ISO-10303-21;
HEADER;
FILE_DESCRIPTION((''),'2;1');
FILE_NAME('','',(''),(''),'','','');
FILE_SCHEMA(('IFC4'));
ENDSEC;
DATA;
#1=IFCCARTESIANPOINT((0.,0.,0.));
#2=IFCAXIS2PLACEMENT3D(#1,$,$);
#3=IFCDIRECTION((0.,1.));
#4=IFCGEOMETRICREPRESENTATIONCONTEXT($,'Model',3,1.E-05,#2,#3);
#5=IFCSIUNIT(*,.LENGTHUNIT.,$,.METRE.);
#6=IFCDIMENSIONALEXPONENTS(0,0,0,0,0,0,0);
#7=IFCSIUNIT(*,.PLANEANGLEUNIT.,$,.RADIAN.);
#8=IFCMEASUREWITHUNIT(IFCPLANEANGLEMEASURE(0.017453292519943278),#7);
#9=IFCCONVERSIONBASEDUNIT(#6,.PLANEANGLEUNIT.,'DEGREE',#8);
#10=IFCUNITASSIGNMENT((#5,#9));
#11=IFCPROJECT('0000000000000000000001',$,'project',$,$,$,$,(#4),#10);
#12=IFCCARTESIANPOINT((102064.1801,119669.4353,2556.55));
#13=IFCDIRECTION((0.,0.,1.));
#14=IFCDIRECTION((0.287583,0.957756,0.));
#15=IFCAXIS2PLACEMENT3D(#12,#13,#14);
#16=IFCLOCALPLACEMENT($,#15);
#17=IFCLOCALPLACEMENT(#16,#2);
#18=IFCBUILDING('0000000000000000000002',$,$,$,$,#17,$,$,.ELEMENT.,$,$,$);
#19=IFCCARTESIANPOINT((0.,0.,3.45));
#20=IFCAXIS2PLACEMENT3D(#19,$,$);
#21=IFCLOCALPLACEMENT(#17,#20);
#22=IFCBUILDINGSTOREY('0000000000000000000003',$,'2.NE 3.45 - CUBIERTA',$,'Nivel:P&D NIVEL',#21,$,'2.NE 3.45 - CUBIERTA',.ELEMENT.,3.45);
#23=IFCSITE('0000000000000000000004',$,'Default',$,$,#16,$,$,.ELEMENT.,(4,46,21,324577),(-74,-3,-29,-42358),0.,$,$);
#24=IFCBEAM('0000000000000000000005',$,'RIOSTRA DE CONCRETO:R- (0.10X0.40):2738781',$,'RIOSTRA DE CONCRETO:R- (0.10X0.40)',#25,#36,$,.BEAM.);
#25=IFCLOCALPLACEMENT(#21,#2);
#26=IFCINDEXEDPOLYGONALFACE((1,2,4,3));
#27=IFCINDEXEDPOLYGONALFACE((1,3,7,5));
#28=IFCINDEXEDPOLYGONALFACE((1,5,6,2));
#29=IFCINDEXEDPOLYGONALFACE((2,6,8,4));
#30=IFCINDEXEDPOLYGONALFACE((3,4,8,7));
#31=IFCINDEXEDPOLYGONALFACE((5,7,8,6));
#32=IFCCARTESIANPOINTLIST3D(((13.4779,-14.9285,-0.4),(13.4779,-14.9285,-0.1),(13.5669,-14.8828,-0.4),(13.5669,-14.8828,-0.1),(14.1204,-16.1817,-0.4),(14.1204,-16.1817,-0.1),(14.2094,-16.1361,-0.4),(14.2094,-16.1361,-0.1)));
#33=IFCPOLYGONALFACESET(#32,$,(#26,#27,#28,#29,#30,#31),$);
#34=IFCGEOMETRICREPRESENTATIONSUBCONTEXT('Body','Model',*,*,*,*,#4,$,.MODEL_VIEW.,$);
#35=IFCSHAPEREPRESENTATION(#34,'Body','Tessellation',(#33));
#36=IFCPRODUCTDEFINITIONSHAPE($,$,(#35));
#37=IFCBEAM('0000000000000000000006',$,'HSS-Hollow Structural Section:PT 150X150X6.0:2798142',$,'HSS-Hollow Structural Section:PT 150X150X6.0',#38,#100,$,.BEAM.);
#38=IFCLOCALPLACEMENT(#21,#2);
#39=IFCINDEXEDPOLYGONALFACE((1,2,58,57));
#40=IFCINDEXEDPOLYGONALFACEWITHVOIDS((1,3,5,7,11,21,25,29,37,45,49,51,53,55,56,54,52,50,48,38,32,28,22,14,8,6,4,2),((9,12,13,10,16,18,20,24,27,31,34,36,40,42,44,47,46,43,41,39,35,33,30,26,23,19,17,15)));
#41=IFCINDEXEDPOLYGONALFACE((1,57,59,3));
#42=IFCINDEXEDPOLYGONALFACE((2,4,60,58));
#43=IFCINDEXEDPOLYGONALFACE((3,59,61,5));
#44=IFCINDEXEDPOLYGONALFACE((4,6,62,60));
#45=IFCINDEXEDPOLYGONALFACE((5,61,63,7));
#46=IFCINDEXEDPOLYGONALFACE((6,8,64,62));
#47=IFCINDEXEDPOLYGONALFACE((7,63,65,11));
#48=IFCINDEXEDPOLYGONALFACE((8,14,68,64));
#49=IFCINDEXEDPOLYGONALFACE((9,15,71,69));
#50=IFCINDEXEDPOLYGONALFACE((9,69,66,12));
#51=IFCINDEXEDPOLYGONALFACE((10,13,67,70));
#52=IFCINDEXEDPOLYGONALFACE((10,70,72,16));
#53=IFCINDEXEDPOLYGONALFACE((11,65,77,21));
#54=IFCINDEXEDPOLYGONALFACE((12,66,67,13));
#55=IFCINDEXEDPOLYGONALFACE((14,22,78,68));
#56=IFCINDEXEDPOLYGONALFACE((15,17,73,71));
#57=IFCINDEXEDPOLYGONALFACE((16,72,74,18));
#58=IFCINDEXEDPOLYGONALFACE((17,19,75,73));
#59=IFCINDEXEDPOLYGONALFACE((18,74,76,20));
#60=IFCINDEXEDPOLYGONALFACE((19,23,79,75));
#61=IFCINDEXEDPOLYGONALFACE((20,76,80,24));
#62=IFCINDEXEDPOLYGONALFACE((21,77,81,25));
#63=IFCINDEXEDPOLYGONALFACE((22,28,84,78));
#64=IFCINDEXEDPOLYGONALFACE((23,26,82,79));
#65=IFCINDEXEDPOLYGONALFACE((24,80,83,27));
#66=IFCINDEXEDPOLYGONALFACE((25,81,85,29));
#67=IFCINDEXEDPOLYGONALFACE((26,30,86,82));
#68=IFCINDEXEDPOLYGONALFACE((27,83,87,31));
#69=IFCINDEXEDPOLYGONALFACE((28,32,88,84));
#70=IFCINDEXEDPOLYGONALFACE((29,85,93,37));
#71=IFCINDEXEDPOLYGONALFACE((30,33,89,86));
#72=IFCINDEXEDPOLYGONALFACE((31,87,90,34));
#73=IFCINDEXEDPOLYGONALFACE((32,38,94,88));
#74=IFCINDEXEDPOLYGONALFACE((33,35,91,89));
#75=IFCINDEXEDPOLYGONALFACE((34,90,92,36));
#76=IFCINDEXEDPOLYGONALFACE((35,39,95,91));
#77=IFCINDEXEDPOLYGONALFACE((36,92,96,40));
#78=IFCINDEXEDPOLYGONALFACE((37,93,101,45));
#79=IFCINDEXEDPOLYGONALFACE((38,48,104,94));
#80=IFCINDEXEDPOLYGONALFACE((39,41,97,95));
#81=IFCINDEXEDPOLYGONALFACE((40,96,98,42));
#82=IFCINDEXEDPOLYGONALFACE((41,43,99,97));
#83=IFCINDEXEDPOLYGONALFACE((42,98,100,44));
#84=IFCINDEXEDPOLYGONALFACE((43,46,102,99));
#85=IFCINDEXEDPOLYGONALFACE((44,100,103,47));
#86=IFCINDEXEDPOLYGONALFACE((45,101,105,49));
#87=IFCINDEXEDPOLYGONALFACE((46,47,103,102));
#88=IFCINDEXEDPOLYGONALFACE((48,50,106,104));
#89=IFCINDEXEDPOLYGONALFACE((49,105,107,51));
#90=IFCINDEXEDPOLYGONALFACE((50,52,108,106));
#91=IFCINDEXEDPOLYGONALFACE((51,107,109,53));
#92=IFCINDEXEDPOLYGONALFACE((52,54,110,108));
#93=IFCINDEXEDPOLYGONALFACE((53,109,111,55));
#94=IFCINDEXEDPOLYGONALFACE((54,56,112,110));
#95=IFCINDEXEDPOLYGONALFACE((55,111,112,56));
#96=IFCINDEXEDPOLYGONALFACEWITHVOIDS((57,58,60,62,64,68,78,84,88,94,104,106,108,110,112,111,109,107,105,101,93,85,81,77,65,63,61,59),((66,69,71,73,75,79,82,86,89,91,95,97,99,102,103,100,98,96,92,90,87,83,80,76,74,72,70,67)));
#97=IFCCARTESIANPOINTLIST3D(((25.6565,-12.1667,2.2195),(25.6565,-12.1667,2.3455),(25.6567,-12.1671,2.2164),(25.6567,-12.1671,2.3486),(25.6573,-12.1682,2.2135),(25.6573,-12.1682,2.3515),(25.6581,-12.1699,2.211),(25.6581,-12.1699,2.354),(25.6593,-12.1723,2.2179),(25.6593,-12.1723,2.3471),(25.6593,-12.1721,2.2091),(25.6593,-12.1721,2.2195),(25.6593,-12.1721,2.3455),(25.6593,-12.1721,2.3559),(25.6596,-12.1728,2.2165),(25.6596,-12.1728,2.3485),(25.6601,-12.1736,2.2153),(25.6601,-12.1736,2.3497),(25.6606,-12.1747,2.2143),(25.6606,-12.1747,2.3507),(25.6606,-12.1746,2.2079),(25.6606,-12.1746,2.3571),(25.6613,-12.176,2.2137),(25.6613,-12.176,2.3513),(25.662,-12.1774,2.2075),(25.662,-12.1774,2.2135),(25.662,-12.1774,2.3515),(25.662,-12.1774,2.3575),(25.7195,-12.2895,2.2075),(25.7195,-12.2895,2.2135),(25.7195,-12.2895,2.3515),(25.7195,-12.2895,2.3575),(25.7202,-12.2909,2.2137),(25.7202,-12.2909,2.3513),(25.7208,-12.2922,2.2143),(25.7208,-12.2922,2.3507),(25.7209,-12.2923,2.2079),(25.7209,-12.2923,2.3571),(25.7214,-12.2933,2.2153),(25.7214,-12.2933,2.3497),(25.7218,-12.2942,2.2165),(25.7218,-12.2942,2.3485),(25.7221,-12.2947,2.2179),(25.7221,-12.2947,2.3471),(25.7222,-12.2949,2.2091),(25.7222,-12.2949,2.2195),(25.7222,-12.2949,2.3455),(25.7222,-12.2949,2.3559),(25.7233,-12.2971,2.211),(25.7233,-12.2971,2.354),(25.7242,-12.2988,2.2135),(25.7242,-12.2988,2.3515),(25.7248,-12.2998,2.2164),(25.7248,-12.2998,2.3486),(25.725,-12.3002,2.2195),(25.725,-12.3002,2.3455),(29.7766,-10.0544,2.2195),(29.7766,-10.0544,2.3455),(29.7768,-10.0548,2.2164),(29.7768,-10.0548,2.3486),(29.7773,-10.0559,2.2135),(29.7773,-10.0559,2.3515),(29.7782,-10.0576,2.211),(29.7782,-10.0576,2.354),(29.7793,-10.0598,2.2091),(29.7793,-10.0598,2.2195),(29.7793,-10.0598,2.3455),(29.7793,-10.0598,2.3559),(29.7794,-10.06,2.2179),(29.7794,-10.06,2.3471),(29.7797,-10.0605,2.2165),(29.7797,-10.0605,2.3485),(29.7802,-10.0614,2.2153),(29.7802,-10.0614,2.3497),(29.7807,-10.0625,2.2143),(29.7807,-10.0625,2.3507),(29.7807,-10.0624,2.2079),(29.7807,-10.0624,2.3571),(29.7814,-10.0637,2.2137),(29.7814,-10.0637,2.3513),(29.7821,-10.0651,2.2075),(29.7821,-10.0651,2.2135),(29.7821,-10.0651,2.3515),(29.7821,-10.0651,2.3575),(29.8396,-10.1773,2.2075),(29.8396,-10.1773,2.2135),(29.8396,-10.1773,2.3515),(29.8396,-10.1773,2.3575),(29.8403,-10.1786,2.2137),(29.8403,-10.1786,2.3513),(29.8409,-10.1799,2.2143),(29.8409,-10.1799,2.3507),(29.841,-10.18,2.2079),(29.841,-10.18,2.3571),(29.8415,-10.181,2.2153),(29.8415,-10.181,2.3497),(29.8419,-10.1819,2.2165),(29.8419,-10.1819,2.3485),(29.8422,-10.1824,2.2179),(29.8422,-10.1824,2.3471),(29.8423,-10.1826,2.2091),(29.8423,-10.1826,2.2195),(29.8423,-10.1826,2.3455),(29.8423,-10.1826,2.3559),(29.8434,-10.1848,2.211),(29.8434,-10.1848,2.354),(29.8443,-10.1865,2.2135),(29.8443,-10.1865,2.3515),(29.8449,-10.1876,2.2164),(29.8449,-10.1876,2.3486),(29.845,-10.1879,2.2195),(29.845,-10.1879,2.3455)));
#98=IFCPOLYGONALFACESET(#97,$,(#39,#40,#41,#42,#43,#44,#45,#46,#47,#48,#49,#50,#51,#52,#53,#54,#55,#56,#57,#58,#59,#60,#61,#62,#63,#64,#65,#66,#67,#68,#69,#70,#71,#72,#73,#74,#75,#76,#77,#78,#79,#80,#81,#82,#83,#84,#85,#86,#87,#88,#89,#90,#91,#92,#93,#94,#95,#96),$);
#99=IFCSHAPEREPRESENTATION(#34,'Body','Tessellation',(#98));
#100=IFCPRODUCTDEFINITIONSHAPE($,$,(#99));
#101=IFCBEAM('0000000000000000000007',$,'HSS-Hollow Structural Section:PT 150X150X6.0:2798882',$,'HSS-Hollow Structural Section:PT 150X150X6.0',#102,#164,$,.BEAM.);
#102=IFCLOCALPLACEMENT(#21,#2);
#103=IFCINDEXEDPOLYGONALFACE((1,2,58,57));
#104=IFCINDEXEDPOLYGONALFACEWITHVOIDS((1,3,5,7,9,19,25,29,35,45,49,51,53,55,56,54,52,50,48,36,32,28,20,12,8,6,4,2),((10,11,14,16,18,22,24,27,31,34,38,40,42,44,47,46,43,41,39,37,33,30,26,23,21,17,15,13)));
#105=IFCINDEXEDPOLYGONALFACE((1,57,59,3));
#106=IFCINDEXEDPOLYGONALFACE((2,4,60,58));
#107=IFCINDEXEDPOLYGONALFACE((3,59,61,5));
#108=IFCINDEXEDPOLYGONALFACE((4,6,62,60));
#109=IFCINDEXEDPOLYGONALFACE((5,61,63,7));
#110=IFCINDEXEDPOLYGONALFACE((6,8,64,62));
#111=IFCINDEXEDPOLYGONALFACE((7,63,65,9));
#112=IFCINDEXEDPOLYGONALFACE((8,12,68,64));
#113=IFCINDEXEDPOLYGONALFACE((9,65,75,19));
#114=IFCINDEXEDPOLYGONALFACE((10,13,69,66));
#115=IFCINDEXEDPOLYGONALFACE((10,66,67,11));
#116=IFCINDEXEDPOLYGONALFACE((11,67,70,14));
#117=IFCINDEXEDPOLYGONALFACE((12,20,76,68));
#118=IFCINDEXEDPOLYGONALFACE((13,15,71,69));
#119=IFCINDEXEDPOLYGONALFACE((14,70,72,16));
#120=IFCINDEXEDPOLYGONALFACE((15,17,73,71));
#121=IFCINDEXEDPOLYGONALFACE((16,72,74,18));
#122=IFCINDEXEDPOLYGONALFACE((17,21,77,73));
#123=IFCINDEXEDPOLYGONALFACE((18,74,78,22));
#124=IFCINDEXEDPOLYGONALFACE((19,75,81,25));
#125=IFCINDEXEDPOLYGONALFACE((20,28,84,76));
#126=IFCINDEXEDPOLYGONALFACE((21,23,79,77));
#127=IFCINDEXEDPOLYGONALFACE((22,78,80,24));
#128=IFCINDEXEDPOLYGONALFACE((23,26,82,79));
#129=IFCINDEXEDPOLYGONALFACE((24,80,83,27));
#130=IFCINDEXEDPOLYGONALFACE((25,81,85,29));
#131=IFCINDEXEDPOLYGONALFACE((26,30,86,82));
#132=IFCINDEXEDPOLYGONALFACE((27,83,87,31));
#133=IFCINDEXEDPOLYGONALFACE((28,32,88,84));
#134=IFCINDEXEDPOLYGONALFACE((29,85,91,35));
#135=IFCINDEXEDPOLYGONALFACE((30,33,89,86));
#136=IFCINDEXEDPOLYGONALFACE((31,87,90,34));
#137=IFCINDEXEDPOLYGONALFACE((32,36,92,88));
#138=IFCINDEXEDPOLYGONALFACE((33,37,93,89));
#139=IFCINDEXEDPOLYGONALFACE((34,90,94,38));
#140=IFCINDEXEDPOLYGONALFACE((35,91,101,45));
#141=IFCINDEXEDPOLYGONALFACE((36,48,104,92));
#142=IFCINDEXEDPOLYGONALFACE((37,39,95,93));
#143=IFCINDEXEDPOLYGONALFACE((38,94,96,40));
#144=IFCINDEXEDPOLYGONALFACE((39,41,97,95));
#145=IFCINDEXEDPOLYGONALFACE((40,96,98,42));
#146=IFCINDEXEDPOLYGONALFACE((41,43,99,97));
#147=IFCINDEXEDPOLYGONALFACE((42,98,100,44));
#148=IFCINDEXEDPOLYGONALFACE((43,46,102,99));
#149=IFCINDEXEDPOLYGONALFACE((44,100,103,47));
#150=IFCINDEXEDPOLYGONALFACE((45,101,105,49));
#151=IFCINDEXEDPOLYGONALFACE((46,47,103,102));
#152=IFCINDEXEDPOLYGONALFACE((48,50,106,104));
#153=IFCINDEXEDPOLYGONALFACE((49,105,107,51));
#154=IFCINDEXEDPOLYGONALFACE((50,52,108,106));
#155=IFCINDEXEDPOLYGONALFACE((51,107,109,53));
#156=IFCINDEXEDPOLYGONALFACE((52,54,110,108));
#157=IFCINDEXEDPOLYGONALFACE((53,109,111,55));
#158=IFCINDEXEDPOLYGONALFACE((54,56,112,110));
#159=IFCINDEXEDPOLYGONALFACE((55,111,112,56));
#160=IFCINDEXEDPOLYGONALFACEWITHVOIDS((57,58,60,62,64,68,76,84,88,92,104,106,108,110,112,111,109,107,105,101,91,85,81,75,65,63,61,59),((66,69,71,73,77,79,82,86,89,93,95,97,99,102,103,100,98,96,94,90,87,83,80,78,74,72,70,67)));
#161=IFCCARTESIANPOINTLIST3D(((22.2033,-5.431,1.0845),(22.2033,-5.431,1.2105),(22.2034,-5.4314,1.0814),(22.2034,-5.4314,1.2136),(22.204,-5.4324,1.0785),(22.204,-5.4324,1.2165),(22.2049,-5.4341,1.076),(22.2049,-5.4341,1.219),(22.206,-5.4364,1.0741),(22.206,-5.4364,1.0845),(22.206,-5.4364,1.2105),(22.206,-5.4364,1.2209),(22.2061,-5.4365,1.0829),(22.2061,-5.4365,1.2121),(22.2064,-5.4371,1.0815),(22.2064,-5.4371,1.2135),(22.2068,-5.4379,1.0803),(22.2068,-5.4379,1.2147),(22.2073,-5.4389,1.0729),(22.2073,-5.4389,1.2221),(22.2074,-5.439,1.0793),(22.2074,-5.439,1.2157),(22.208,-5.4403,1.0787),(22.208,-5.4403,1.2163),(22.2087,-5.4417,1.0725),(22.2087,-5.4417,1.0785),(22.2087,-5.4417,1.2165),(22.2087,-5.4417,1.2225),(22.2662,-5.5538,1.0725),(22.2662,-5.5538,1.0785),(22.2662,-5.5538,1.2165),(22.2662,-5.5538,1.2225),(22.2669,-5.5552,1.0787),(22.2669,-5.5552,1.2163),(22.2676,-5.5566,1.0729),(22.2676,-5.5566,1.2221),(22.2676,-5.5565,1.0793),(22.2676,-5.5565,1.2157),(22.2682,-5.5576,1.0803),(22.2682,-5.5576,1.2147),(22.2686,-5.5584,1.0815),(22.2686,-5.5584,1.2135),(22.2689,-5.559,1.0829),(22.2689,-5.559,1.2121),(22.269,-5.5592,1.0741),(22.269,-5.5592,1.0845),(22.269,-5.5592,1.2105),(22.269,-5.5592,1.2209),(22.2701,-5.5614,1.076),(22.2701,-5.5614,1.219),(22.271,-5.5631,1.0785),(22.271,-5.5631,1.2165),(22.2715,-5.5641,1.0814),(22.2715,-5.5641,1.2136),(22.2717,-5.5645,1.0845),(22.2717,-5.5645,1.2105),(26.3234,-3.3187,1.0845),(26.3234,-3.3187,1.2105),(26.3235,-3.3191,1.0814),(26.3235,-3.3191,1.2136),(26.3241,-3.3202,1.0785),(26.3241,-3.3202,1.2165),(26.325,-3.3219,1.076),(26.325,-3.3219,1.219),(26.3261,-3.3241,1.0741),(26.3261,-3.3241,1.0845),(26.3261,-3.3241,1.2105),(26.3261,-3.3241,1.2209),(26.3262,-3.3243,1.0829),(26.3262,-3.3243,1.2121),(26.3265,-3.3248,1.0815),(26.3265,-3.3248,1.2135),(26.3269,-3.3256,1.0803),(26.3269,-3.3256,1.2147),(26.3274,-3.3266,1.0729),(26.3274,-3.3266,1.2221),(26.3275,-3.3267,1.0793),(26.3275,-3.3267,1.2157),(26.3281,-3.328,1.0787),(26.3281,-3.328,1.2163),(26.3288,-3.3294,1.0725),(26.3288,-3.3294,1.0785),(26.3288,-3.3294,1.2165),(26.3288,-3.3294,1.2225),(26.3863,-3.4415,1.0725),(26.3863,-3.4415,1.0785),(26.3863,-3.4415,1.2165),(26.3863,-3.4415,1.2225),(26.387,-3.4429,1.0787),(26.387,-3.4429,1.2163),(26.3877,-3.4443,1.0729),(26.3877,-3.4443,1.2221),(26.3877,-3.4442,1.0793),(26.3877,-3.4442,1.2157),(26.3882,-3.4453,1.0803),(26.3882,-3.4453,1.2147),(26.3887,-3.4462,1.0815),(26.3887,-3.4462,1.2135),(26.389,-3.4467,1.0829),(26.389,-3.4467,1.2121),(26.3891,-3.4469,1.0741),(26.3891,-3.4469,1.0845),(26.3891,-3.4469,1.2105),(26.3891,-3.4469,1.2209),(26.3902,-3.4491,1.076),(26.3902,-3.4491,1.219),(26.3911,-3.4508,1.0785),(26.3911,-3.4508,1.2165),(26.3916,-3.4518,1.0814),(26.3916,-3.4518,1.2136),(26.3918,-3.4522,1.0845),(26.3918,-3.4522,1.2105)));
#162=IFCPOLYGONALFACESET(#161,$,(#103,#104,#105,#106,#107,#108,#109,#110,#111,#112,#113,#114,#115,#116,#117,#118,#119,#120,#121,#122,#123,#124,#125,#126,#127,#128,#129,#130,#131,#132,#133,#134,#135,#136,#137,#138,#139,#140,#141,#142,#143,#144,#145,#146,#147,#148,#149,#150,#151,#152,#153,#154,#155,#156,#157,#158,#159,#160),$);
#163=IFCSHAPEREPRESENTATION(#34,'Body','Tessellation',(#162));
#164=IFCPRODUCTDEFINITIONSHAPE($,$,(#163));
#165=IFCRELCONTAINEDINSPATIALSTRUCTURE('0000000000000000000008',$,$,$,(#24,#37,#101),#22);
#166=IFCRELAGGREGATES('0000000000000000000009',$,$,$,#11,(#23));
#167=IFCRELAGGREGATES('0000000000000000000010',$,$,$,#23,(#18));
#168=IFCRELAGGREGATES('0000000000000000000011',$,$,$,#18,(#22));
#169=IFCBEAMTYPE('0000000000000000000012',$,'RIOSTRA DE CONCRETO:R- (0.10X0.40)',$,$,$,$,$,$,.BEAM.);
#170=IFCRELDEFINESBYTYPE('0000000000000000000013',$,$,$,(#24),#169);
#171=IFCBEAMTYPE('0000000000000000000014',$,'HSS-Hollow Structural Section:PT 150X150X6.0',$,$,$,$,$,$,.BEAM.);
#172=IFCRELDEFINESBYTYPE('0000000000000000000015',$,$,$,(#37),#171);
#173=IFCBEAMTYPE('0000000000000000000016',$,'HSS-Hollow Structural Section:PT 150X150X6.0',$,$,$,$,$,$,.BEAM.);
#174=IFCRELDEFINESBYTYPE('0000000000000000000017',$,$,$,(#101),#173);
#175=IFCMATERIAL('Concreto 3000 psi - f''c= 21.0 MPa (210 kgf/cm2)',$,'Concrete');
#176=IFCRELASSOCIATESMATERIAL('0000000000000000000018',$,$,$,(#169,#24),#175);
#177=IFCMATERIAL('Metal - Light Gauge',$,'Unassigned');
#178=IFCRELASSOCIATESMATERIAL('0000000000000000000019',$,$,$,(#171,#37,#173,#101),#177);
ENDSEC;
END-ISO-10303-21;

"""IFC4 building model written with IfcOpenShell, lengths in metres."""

from ifc_helpers import new_model, entity, si_unit, converted_unit, direction, frame, origin, place, context, subcontext, project, spatial, line, arc, indexed_curve, outline, extrude, source, transform, mapped, material, type_object, type_shapes, element, save


model = new_model("IFC4")

# Units and contexts
model_context = context("Model", 3, precision=1e-05, world=origin(), true_north=direction((0.0, 1.0)))
body_context = subcontext(model_context, "Body", "Model", "MODEL_VIEW")
ifc_project = project(units=[si_unit("LENGTHUNIT", "METRE"), converted_unit("PLANEANGLEUNIT", "DEGREE", entity("IfcPlaneAngleMeasure", 0.017453292519943278), si_unit("PLANEANGLEUNIT", "RADIAN"), dimensions=[0, 0, 0, 0, 0, 0, 0])], contexts=[model_context])

# Site, building, storey
site_placement = place(None, frame((102064.1801, 119669.4353, 2556.55), z_axis=(0.0, 0.0, 1.0), x_axis=(0.287583, 0.957756, 0.0)))
site = spatial("IfcSite", under=ifc_project, at=site_placement, Name="Default", CompositionType="ELEMENT", RefLatitude=(4, 46, 21, 324577), RefLongitude=(-74, -3, -29, -42358), RefElevation=0.0)
building_placement = place(site_placement, origin())
building = spatial("IfcBuilding", under=site, at=building_placement, CompositionType="ELEMENT")
storey_placement = place(building_placement, frame((0.0, 0.0, 3.45)))
storey = spatial("IfcBuildingStorey", under=building, at=storey_placement, Name="2.NE 3.45 - CUBIERTA", ObjectType="Nivel:P&D NIVEL", LongName="2.NE 3.45 - CUBIERTA", CompositionType="ELEMENT", Elevation=3.45)

# Beams
ifc_material_1 = material(Name="Metal - Light Gauge", Category="Unassigned")
ifc_material_2 = material(Name="Concreto 3000 psi - f'c= 21.0 MPa (210 kgf/cm2)", Category="Concrete")
beam_type_1 = type_object("IfcBeamType", Name="RIOSTRA DE CONCRETO:R- (0.10X0.40)", PredefinedType="BEAM", material=ifc_material_2)
shared_shape_1 = source(origin(), body_context, "Body", "SweptSolid", [
    extrude(outline(indexed_curve([(-0.15, -0.05), (0.15, -0.05), (0.15, 0.05), (-0.15, 0.05), (-0.15, -0.05)], self_intersect=False)), frame((13.5224, -14.9056, 3.2), z_axis=(0.456217, -0.889869, 0.0), x_axis=(0.0, 0.0, -1.0)), (0.0, 0.0, 1.0), 1.4083),
])
type_shapes(beam_type_1, [shared_shape_1])
beam_1_placement = place(storey_placement, frame((0.0, 0.0, -3.45)))
element("IfcBeam", 1, at=beam_1_placement, inside=storey, type_object=beam_type_1, material=ifc_material_2, Name="RIOSTRA DE CONCRETO:R- (0.10X0.40):2738781", ObjectType="RIOSTRA DE CONCRETO:R- (0.10X0.40)", PredefinedType="BEAM", context=body_context, shape_type="MappedRepresentation", body=[
    mapped(shared_shape_1, transform((0.0, 0.0, 0.0), scale=1.0)),
])
beam_type_2 = type_object("IfcBeamType", Name="HSS-Hollow Structural Section:PT 150X150X6.0", PredefinedType="BEAM", material=ifc_material_1)
shared_shape_2 = source(origin(), body_context, "Body", "SweptSolid", [
    extrude(outline(indexed_curve([(-0.063, -0.075), (0.063, -0.075), (0.0715, -0.0715), (0.075, -0.063), (0.075, 0.063), (0.0715, 0.0715), (0.063, 0.075), (-0.063, 0.075), (-0.0715, 0.0715), (-0.075, 0.063), (-0.075, -0.063), (-0.0715, -0.0715)], segments=[line(1, 2), arc(2, 3, 4), line(4, 5), arc(5, 6, 7), line(7, 8), arc(8, 9, 10), line(10, 11), arc(11, 12, 1)], self_intersect=False), holes=[indexed_curve([(-0.069, 0.063), (-0.0672, 0.0672), (-0.063, 0.069), (0.063, 0.069), (0.0672, 0.0672), (0.069, 0.063), (0.069, -0.063), (0.0672, -0.0672), (0.063, -0.069), (-0.063, -0.069), (-0.0672, -0.0672), (-0.069, -0.063)], segments=[arc(1, 2, 3), line(3, 4), arc(4, 5, 6), line(6, 7), arc(7, 8, 9), line(9, 10), arc(10, 11, 12), line(12, 1)], self_intersect=False)]), frame((25.6907, -12.2335, 5.7325), z_axis=(0.889869, 0.456217, 0.0), x_axis=(0.0, 0.0, -1.0)), (0.0, 0.0, 1.0), 4.63),
])
type_shapes(beam_type_2, [shared_shape_2])
beam_2_placement = place(storey_placement, frame((0.0, 0.0, -3.45)))
element("IfcBeam", 2, at=beam_2_placement, inside=storey, type_object=beam_type_2, material=ifc_material_1, Name="HSS-Hollow Structural Section:PT 150X150X6.0:2798142", ObjectType="HSS-Hollow Structural Section:PT 150X150X6.0", PredefinedType="BEAM", context=body_context, shape_type="MappedRepresentation", body=[
    mapped(shared_shape_2, transform((0.0, 0.0, 0.0), scale=1.0)),
])
beam_type_3 = type_object("IfcBeamType", Name="HSS-Hollow Structural Section:PT 150X150X6.0", PredefinedType="BEAM", material=ifc_material_1)
shared_shape_3 = source(origin(), body_context, "Body", "SweptSolid", [
    extrude(outline(indexed_curve([(-0.063, -0.075), (0.063, -0.075), (0.0715, -0.0715), (0.075, -0.063), (0.075, 0.063), (0.0715, 0.0715), (0.063, 0.075), (-0.063, 0.075), (-0.0715, 0.0715), (-0.075, 0.063), (-0.075, -0.063), (-0.0715, -0.0715)], segments=[line(1, 2), arc(2, 3, 4), line(4, 5), arc(5, 6, 7), line(7, 8), arc(8, 9, 10), line(10, 11), arc(11, 12, 1)], self_intersect=False), holes=[indexed_curve([(-0.069, 0.063), (-0.0672, 0.0672), (-0.063, 0.069), (0.063, 0.069), (0.0672, 0.0672), (0.069, 0.063), (0.069, -0.063), (0.0672, -0.0672), (0.063, -0.069), (-0.063, -0.069), (-0.0672, -0.0672), (-0.069, -0.063)], segments=[arc(1, 2, 3), line(3, 4), arc(4, 5, 6), line(6, 7), arc(7, 8, 9), line(9, 10), arc(10, 11, 12), line(12, 1)], self_intersect=False)]), frame((22.2375, -5.4978, 4.5975), z_axis=(0.889869, 0.456217, 0.0), x_axis=(0.0, 0.0, -1.0)), (0.0, 0.0, 1.0), 4.63),
])
type_shapes(beam_type_3, [shared_shape_3])
beam_3_placement = place(storey_placement, frame((0.0, 0.0, -3.45)))
element("IfcBeam", 3, at=beam_3_placement, inside=storey, type_object=beam_type_3, material=ifc_material_1, Name="HSS-Hollow Structural Section:PT 150X150X6.0:2798882", ObjectType="HSS-Hollow Structural Section:PT 150X150X6.0", PredefinedType="BEAM", context=body_context, shape_type="MappedRepresentation", body=[
    mapped(shared_shape_3, transform((0.0, 0.0, 0.0), scale=1.0)),
])

save(model, "model.ifc")
